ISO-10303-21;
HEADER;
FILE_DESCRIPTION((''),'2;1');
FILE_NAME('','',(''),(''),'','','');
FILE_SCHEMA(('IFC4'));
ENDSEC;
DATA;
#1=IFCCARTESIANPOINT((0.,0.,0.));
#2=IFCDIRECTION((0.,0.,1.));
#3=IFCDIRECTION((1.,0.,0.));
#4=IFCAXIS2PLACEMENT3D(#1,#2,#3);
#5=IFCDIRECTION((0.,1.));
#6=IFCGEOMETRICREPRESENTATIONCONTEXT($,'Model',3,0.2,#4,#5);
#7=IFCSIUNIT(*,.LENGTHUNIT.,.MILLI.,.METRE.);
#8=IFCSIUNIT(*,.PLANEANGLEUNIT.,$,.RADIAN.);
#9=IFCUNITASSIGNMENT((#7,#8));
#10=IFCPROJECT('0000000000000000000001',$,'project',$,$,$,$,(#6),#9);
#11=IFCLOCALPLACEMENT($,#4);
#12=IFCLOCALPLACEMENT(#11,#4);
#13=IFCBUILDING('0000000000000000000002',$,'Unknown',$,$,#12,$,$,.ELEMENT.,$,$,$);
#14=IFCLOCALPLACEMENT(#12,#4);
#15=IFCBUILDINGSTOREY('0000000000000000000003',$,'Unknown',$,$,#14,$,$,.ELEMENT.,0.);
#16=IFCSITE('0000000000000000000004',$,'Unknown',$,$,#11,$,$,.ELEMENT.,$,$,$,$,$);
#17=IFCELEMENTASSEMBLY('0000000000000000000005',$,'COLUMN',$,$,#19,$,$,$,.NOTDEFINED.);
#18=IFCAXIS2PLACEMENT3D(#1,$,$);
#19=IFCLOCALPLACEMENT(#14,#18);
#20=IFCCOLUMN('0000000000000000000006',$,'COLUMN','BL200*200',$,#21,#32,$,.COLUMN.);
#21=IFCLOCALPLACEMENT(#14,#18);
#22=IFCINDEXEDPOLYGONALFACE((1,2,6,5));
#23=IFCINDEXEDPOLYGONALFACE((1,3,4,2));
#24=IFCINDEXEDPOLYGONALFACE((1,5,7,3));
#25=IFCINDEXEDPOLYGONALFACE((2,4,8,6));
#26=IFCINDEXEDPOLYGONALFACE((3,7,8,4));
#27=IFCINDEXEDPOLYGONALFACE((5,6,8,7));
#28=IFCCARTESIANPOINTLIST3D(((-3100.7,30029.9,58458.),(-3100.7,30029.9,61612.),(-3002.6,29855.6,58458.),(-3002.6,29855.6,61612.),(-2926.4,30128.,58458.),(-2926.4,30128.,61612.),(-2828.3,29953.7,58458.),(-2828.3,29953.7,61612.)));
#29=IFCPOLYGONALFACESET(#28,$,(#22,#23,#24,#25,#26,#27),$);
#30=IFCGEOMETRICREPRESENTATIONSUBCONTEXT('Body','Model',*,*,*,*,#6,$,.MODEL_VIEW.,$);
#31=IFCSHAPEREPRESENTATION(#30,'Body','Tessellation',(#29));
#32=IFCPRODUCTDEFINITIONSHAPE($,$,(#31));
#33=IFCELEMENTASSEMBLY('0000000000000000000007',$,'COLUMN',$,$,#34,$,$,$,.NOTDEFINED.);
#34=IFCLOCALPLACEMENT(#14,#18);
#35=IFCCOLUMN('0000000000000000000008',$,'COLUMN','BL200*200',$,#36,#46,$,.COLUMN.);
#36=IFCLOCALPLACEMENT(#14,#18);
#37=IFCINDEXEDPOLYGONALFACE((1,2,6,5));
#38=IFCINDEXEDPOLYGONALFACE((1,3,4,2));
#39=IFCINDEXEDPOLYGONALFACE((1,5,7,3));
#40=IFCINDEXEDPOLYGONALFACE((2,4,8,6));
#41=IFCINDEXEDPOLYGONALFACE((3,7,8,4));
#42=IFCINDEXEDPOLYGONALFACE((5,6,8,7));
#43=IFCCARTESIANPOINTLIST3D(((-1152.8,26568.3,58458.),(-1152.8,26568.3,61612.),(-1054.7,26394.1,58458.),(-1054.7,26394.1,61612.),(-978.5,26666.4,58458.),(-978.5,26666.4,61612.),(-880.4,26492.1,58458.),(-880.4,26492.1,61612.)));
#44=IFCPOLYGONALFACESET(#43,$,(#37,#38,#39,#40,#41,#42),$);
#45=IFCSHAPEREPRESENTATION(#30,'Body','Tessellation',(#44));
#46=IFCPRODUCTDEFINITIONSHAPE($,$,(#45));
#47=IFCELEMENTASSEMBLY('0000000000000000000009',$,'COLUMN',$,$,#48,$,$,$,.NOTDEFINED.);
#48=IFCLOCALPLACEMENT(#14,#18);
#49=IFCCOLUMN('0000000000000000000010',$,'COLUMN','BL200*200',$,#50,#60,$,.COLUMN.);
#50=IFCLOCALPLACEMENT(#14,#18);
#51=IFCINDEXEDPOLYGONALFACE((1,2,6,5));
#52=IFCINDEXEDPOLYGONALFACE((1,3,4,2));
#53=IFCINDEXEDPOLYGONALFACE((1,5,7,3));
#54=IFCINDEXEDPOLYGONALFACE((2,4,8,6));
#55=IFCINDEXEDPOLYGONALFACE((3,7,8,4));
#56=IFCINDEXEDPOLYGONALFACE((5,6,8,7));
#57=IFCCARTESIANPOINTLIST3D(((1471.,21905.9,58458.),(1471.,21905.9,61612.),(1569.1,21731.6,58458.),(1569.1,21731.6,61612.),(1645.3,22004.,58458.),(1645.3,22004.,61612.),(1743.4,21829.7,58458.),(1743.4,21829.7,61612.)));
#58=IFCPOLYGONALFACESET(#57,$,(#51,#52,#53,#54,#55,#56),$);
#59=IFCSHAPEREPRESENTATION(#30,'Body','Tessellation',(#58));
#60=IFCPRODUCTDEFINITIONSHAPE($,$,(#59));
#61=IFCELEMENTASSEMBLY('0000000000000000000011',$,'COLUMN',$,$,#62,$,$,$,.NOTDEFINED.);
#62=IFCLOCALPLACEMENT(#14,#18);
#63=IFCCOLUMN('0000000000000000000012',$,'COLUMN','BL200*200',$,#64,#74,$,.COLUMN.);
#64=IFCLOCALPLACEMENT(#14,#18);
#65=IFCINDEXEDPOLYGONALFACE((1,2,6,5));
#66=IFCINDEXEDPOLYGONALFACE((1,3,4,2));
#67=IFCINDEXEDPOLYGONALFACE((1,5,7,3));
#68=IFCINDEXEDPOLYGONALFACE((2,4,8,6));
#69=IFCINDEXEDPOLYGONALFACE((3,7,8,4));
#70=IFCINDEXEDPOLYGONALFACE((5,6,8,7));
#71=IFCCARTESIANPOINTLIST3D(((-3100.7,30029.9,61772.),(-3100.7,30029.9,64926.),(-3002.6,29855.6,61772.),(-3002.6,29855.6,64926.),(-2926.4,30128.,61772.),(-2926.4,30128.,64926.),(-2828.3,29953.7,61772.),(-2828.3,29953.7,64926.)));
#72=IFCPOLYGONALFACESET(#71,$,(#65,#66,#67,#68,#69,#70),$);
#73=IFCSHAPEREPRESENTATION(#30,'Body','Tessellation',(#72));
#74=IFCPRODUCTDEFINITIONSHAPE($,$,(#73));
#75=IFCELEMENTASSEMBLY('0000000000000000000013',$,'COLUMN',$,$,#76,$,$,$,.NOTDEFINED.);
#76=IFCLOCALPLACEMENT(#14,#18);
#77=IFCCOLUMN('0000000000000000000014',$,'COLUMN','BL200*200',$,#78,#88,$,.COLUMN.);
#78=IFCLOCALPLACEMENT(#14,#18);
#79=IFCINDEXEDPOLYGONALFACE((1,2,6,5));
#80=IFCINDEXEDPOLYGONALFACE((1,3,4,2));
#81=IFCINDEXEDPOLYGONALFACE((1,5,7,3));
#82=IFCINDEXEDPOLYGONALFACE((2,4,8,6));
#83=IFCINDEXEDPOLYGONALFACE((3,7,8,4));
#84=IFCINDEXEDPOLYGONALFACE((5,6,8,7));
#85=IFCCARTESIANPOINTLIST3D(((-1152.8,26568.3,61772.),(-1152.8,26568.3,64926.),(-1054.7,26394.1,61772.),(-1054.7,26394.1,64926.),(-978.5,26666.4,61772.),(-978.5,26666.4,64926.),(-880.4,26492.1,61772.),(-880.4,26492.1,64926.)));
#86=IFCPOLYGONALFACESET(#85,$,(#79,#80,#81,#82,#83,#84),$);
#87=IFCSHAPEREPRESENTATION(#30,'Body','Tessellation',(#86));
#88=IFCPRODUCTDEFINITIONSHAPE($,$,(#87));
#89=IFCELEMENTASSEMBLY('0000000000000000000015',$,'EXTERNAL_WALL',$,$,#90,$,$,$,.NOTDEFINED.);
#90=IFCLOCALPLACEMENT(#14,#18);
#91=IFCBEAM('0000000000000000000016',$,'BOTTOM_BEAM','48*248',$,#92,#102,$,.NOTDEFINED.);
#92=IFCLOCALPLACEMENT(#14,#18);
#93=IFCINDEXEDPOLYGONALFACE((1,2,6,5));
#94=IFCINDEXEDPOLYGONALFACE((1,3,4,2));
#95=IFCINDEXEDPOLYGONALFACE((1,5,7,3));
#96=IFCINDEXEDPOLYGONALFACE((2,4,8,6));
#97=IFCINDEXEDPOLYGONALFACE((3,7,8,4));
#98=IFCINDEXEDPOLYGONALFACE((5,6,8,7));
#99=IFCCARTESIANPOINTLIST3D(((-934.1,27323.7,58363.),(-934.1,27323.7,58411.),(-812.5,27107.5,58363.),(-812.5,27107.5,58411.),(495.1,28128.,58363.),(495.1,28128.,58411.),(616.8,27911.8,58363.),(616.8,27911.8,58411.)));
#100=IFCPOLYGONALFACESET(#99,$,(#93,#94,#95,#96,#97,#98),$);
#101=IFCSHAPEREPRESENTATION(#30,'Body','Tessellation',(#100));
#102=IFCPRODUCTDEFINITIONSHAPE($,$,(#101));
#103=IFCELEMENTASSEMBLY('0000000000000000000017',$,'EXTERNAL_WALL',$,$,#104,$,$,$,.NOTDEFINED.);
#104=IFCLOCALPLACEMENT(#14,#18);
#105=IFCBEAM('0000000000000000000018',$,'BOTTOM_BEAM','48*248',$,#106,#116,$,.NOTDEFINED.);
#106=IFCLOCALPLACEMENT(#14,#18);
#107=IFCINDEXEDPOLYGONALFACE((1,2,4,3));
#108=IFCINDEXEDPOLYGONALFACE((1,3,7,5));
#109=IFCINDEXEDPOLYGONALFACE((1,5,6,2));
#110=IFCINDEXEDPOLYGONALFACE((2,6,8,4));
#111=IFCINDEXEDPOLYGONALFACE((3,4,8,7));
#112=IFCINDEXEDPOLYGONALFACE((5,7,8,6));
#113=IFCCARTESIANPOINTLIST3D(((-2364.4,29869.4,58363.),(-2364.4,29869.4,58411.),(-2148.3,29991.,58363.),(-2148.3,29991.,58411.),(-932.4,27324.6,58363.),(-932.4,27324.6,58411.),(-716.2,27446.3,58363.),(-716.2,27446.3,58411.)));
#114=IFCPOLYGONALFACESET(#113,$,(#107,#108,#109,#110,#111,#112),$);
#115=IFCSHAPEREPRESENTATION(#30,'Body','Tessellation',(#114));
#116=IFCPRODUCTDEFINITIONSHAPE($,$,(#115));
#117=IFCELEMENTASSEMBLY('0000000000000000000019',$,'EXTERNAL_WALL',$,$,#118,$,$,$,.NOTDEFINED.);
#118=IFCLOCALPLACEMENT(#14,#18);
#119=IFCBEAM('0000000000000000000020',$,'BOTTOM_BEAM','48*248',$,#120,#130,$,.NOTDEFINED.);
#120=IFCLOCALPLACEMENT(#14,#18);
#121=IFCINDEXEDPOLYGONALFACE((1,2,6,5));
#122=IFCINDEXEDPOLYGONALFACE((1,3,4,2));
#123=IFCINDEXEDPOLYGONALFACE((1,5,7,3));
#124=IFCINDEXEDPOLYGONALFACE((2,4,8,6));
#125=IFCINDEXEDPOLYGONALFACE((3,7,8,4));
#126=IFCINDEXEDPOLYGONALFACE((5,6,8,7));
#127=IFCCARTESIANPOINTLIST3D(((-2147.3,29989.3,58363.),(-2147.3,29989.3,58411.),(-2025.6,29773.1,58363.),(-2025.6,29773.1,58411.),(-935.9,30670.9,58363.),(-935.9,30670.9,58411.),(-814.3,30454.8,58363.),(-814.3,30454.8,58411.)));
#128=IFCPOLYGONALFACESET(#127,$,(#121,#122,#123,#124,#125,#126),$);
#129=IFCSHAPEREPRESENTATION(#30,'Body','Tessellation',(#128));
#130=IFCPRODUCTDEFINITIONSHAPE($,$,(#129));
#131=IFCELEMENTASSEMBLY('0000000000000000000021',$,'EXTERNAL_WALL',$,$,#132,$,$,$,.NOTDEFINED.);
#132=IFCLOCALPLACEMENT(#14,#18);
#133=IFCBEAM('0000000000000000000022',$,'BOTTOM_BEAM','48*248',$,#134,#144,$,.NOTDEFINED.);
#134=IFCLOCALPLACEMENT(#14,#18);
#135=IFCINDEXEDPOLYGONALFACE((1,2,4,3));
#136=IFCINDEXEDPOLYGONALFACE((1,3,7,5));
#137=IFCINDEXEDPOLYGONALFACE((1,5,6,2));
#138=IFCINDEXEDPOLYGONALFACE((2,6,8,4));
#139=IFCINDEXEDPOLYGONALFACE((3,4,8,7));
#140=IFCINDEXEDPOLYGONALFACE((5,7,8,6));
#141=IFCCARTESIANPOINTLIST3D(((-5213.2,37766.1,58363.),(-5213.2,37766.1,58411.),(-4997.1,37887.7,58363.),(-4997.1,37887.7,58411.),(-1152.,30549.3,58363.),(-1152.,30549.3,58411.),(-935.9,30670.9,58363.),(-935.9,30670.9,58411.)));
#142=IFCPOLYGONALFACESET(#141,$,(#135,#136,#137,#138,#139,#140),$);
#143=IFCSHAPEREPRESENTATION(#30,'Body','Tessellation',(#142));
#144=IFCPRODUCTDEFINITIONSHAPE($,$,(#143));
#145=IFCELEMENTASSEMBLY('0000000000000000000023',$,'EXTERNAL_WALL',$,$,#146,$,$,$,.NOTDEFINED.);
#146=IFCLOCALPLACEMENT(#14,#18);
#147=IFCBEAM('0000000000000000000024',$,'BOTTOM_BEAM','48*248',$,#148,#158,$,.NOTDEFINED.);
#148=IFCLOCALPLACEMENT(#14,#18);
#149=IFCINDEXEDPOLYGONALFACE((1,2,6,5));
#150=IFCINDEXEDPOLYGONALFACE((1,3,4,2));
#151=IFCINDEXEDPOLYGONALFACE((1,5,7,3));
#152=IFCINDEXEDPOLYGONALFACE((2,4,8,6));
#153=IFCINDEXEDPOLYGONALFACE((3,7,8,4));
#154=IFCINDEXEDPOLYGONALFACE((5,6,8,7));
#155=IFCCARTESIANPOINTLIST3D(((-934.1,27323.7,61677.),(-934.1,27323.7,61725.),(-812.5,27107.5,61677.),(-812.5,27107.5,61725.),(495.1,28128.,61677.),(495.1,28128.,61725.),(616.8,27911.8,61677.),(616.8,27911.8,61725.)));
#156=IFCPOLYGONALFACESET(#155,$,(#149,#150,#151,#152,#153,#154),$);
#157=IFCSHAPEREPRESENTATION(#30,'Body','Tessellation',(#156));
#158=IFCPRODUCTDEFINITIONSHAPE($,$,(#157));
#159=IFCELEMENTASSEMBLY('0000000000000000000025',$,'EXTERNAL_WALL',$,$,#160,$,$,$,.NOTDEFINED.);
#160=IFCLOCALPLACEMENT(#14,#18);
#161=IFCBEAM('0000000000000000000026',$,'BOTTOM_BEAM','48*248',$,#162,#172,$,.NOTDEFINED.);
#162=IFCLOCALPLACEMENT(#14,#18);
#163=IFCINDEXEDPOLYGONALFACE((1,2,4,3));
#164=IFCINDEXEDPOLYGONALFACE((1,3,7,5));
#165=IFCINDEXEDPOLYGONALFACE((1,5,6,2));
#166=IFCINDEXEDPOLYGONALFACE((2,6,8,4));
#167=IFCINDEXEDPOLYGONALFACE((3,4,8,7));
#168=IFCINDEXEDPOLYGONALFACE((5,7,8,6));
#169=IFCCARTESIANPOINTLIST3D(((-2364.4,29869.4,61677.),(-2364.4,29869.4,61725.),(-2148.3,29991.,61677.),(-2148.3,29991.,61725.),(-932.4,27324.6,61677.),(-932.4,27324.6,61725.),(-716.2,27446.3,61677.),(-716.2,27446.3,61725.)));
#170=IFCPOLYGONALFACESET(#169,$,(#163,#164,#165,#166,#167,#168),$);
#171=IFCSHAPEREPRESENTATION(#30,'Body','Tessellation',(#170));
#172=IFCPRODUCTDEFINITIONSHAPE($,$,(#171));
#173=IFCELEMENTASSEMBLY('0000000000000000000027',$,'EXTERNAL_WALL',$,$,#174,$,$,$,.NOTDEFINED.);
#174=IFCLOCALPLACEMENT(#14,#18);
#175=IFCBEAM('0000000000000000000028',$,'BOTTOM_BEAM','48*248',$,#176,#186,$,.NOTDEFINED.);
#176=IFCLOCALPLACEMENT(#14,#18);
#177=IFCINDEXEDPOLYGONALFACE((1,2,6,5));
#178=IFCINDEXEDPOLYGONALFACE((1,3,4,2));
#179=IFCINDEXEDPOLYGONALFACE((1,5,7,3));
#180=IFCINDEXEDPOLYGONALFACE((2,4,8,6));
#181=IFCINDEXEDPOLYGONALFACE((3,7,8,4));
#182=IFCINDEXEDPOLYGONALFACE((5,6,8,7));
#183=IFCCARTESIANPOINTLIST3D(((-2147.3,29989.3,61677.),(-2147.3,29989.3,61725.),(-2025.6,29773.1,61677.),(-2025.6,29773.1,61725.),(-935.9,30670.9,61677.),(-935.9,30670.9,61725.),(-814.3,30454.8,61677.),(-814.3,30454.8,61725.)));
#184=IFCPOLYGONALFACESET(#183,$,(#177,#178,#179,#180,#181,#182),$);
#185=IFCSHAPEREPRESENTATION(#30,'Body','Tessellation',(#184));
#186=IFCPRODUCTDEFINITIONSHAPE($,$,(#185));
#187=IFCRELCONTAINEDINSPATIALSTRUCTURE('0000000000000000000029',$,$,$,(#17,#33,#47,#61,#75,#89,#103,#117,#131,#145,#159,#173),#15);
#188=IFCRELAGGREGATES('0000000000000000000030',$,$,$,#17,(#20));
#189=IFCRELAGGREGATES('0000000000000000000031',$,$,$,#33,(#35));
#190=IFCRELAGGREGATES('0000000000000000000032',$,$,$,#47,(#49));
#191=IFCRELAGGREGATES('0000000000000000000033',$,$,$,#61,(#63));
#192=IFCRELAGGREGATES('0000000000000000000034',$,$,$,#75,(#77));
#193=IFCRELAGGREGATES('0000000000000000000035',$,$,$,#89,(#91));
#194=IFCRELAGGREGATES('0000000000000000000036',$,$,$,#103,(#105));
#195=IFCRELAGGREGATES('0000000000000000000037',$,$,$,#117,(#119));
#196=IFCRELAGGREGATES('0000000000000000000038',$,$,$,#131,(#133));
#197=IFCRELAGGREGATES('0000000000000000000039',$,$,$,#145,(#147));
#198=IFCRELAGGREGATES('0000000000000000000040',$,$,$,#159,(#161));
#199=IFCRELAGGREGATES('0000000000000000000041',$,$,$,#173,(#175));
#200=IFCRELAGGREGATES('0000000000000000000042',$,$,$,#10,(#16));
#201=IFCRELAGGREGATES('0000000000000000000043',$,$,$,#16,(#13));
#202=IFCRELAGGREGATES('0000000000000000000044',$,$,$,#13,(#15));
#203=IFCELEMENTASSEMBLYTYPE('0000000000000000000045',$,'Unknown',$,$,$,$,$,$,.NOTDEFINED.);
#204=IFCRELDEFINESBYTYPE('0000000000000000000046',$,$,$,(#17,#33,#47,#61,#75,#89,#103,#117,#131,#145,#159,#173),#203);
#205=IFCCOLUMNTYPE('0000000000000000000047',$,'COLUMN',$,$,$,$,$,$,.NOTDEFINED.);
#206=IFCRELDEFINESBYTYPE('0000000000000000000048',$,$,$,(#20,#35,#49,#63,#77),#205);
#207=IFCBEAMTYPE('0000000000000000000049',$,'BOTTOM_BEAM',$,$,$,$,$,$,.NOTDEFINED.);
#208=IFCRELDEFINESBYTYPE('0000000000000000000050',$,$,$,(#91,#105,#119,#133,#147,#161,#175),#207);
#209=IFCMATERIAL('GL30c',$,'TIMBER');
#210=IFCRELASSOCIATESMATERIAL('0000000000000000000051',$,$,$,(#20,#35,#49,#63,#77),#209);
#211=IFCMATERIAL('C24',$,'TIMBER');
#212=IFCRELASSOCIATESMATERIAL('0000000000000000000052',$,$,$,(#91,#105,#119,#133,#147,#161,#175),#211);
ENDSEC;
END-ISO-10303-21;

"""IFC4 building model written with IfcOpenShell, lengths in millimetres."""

from ifc_helpers import new_model, si_unit, direction, frame, origin_with_axes, origin_2d_with_axis, place, context, subcontext, project, spatial, rectangle, extrude, material, material_profile, profile_set, profile_usage, type_object, element, aggregate, save


model = new_model("IFC4")

# Units and contexts
model_context = context("Model", 3, precision=0.2, world=origin_with_axes(), true_north=direction((0.0, 1.0)))
body_context = subcontext(model_context, "Body", "Model", "MODEL_VIEW")
ifc_project = project(units=[si_unit("LENGTHUNIT", "METRE", prefix="MILLI"), si_unit("PLANEANGLEUNIT", "RADIAN")], contexts=[model_context])

# Site, building, storey
site_placement = place(None, origin_with_axes())
site = spatial("IfcSite", under=ifc_project, at=site_placement, Name="Unknown", CompositionType="ELEMENT")
building_placement = place(site_placement, origin_with_axes())
building = spatial("IfcBuilding", under=site, at=building_placement, Name="Unknown", CompositionType="ELEMENT")
storey_placement = place(building_placement, origin_with_axes())
storey = spatial("IfcBuildingStorey", under=building, at=storey_placement, Name="Unknown", CompositionType="ELEMENT", Elevation=0.0)

# Element assemblies, columns
element_assembly_type = type_object("IfcElementAssemblyType", Name="Unknown", PredefinedType="NOTDEFINED")
assembly_1_placement = place(storey_placement, frame((-2964.5, 29991.8, 58458.0), z_axis=(-0.871487, -0.490418, 0.0), x_axis=(0.0, 0.0, 1.0)))
assembly_1 = element("IfcElementAssembly", 1, at=assembly_1_placement, inside=storey, type_object=element_assembly_type, Name="COLUMN", PredefinedType="NOTDEFINED")
ifc_material_1 = material(Name="GL30c", Category="TIMBER")
ifc_material_profile_1 = material_profile(ifc_material_1, rectangle(XDim=200.0, YDim=200.0, at=origin_2d_with_axis()), Name="BL200*200")
ifc_profile_set_1 = profile_set([ifc_material_profile_1])
ifc_profile_usage_1 = profile_usage(ifc_profile_set_1, cardinal=5)
column_type = type_object("IfcColumnType", Name="COLUMN")
column_1_placement = place(assembly_1_placement, origin_with_axes())
column_1 = element("IfcColumn", 2, at=column_1_placement, type_object=column_type, material=ifc_profile_usage_1, Name="COLUMN", Description="BL200*200", PredefinedType="COLUMN", context=body_context, shape_type="SolidModel", body=[
    extrude(rectangle(XDim=200.0, YDim=200.0, at=origin_2d_with_axis()), frame((0.0, 0.0, 0.0), z_axis=(-1.0, 0.0, 0.0), x_axis=(0.0, 0.0, 1.0)), (0.0, 0.0, -1.0), 3154.0),
])
aggregate(assembly_1, [column_1])
assembly_2_placement = place(storey_placement, frame((-1016.6, 26530.2, 58458.0), z_axis=(-0.871487, -0.490418, 0.0), x_axis=(0.0, 0.0, 1.0)))
assembly_2 = element("IfcElementAssembly", 3, at=assembly_2_placement, inside=storey, type_object=element_assembly_type, Name="COLUMN", PredefinedType="NOTDEFINED")
column_2_placement = place(assembly_2_placement, origin_with_axes())
column_2 = element("IfcColumn", 4, at=column_2_placement, type_object=column_type, material=ifc_profile_usage_1, Name="COLUMN", Description="BL200*200", PredefinedType="COLUMN", context=body_context, shape_type="SolidModel", body=[
    extrude(rectangle(XDim=200.0, YDim=200.0, at=origin_2d_with_axis()), frame((0.0, 0.0, 0.0), z_axis=(-1.0, 0.0, 0.0), x_axis=(0.0, 0.0, 1.0)), (0.0, 0.0, -1.0), 3154.0),
])
aggregate(assembly_2, [column_2])
assembly_3_placement = place(storey_placement, frame((1607.2, 21867.8, 58458.0), z_axis=(-0.871487, -0.490418, 0.0), x_axis=(0.0, 0.0, 1.0)))
assembly_3 = element("IfcElementAssembly", 5, at=assembly_3_placement, inside=storey, type_object=element_assembly_type, Name="COLUMN", PredefinedType="NOTDEFINED")
column_3_placement = place(assembly_3_placement, origin_with_axes())
column_3 = element("IfcColumn", 6, at=column_3_placement, type_object=column_type, material=ifc_profile_usage_1, Name="COLUMN", Description="BL200*200", PredefinedType="COLUMN", context=body_context, shape_type="SolidModel", body=[
    extrude(rectangle(XDim=200.0, YDim=200.0, at=origin_2d_with_axis()), frame((0.0, 0.0, 0.0), z_axis=(-1.0, 0.0, 0.0), x_axis=(0.0, 0.0, 1.0)), (0.0, 0.0, -1.0), 3154.0),
])
aggregate(assembly_3, [column_3])
assembly_4_placement = place(storey_placement, frame((-2964.5, 29991.8, 61772.0), z_axis=(-0.871487, -0.490418, 0.0), x_axis=(0.0, 0.0, 1.0)))
assembly_4 = element("IfcElementAssembly", 7, at=assembly_4_placement, inside=storey, type_object=element_assembly_type, Name="COLUMN", PredefinedType="NOTDEFINED")
column_4_placement = place(assembly_4_placement, origin_with_axes())
column_4 = element("IfcColumn", 8, at=column_4_placement, type_object=column_type, material=ifc_profile_usage_1, Name="COLUMN", Description="BL200*200", PredefinedType="COLUMN", context=body_context, shape_type="SolidModel", body=[
    extrude(rectangle(XDim=200.0, YDim=200.0, at=origin_2d_with_axis()), frame((0.0, 0.0, 0.0), z_axis=(-1.0, 0.0, 0.0), x_axis=(0.0, 0.0, 1.0)), (0.0, 0.0, -1.0), 3154.0),
])
aggregate(assembly_4, [column_4])
assembly_5_placement = place(storey_placement, frame((-1016.6, 26530.2, 61772.0), z_axis=(-0.871487, -0.490418, 0.0), x_axis=(0.0, 0.0, 1.0)))
assembly_5 = element("IfcElementAssembly", 9, at=assembly_5_placement, inside=storey, type_object=element_assembly_type, Name="COLUMN", PredefinedType="NOTDEFINED")
column_5_placement = place(assembly_5_placement, origin_with_axes())
column_5 = element("IfcColumn", 10, at=column_5_placement, type_object=column_type, material=ifc_profile_usage_1, Name="COLUMN", Description="BL200*200", PredefinedType="COLUMN", context=body_context, shape_type="SolidModel", body=[
    extrude(rectangle(XDim=200.0, YDim=200.0, at=origin_2d_with_axis()), frame((0.0, 0.0, 0.0), z_axis=(-1.0, 0.0, 0.0), x_axis=(0.0, 0.0, 1.0)), (0.0, 0.0, -1.0), 3154.0),
])
aggregate(assembly_5, [column_5])

# Element assemblies, beams
assembly_6_placement = place(storey_placement, frame((556.0, 28019.9, 61622.0), z_axis=(-0.490421, 0.871486, 0.0), x_axis=(-0.871487, -0.490418, 0.0)))
assembly_6 = element("IfcElementAssembly", 11, at=assembly_6_placement, inside=storey, type_object=element_assembly_type, Name="EXTERNAL_WALL", PredefinedType="NOTDEFINED")
ifc_material_2 = material(Name="C24", Category="TIMBER")
ifc_material_profile_2 = material_profile(ifc_material_2, rectangle(XDim=248.0, YDim=48.0, at=origin_2d_with_axis()), Name="48*248")
ifc_profile_set_2 = profile_set([ifc_material_profile_2])
ifc_profile_usage_2 = profile_usage(ifc_profile_set_2, cardinal=3)
beam_type_1 = type_object("IfcBeamType", Name="BOTTOM_BEAM")
beam_1_placement = place(assembly_6_placement, frame((0.0, -3235.0, 0.0), z_axis=(0.0, 0.0, 1.0), x_axis=(1.0, 0.0, 0.0)))
beam_1 = element("IfcBeam", 12, at=beam_1_placement, type_object=beam_type_1, material=ifc_profile_usage_2, Name="BOTTOM_BEAM", Description="48*248", PredefinedType="NOTDEFINED", context=body_context, shape_type="SolidModel", body=[
    extrude(rectangle(XDim=248.0, YDim=48.0, at=origin_2d_with_axis()), frame((0.0, 0.0, 0.0), z_axis=(-1.0, 0.0, 0.0), x_axis=(0.0, 0.0, 1.0)), (0.0, 0.0, -1.0), 1640.0),
])
assembly_7_placement = place(storey_placement, frame((-824.3, 27385.5, 61622.0), z_axis=(0.871484, 0.490423, 0.0), x_axis=(-0.490421, 0.871486, 0.0)))
assembly_7 = element("IfcElementAssembly", 13, at=assembly_7_placement, inside=storey, type_object=element_assembly_type, Name="EXTERNAL_WALL", PredefinedType="NOTDEFINED")
beam_2_placement = place(assembly_7_placement, frame((0.0, -3235.0, 0.0), z_axis=(0.0, 0.0, 1.0), x_axis=(1.0, 0.0, 0.0)))
beam_2 = element("IfcBeam", 14, at=beam_2_placement, type_object=beam_type_1, material=ifc_profile_usage_2, Name="BOTTOM_BEAM", Description="48*248", PredefinedType="NOTDEFINED", context=body_context, shape_type="SolidModel", body=[
    extrude(rectangle(XDim=248.0, YDim=48.0, at=origin_2d_with_axis()), frame((0.0, 0.0, 0.0), z_axis=(-1.0, 0.0, 0.0), x_axis=(0.0, 0.0, 1.0)), (0.0, 0.0, -1.0), 2920.0),
])
assembly_8_placement = place(storey_placement, frame((-2086.5, 29881.2, 61622.0), z_axis=(0.490421, -0.871485, 0.0), x_axis=(0.871484, 0.490423, 0.0)))
assembly_8 = element("IfcElementAssembly", 15, at=assembly_8_placement, inside=storey, type_object=element_assembly_type, Name="EXTERNAL_WALL", PredefinedType="NOTDEFINED")
beam_3_placement = place(assembly_8_placement, frame((0.0, -3235.0, 0.0), z_axis=(0.0, 0.0, 1.0), x_axis=(1.0, 0.0, 0.0)))
beam_3 = element("IfcBeam", 16, at=beam_3_placement, type_object=beam_type_1, material=ifc_profile_usage_2, Name="BOTTOM_BEAM", Description="48*248", PredefinedType="NOTDEFINED", context=body_context, shape_type="SolidModel", body=[
    extrude(rectangle(XDim=248.0, YDim=48.0, at=origin_2d_with_axis()), frame((0.0, 0.0, 0.0), z_axis=(-1.0, 0.0, 0.0), x_axis=(0.0, 0.0, 1.0)), (0.0, 0.0, -1.0), 1390.0),
])
assembly_9_placement = place(storey_placement, frame((-1044.0, 30610.1, 61622.0), z_axis=(0.871484, 0.490423, 0.0), x_axis=(-0.490421, 0.871486, 0.0)))
assembly_9 = element("IfcElementAssembly", 17, at=assembly_9_placement, inside=storey, type_object=element_assembly_type, Name="EXTERNAL_WALL", PredefinedType="NOTDEFINED")
beam_4_placement = place(assembly_9_placement, frame((0.0, -3235.0, 0.0), z_axis=(0.0, 0.0, 1.0), x_axis=(1.0, 0.0, 0.0)))
beam_4 = element("IfcBeam", 18, at=beam_4_placement, type_object=beam_type_1, material=ifc_profile_usage_2, Name="BOTTOM_BEAM", Description="48*248", PredefinedType="NOTDEFINED", context=body_context, shape_type="SolidModel", body=[
    extrude(rectangle(XDim=248.0, YDim=48.0, at=origin_2d_with_axis()), frame((0.0, 0.0, 0.0), z_axis=(-1.0, 0.0, 0.0), x_axis=(0.0, 0.0, 1.0)), (0.0, 0.0, -1.0), 8281.0),
])
assembly_10_placement = place(storey_placement, frame((556.0, 28019.9, 64936.0), z_axis=(-0.490421, 0.871486, 0.0), x_axis=(-0.871487, -0.490418, 0.0)))
assembly_10 = element("IfcElementAssembly", 19, at=assembly_10_placement, inside=storey, type_object=element_assembly_type, Name="EXTERNAL_WALL", PredefinedType="NOTDEFINED")
beam_5_placement = place(assembly_10_placement, frame((0.0, -3235.0, 0.0), z_axis=(0.0, 0.0, 1.0), x_axis=(1.0, 0.0, 0.0)))
beam_5 = element("IfcBeam", 20, at=beam_5_placement, type_object=beam_type_1, material=ifc_profile_usage_2, Name="BOTTOM_BEAM", Description="48*248", PredefinedType="NOTDEFINED", context=body_context, shape_type="SolidModel", body=[
    extrude(rectangle(XDim=248.0, YDim=48.0, at=origin_2d_with_axis()), frame((0.0, 0.0, 0.0), z_axis=(-1.0, 0.0, 0.0), x_axis=(0.0, 0.0, 1.0)), (0.0, 0.0, -1.0), 1640.0),
])
assembly_11_placement = place(storey_placement, frame((-824.3, 27385.5, 64936.0), z_axis=(0.871484, 0.490423, 0.0), x_axis=(-0.490421, 0.871486, 0.0)))
assembly_11 = element("IfcElementAssembly", 21, at=assembly_11_placement, inside=storey, type_object=element_assembly_type, Name="EXTERNAL_WALL", PredefinedType="NOTDEFINED")
beam_6_placement = place(assembly_11_placement, frame((0.0, -3235.0, 0.0), z_axis=(0.0, 0.0, 1.0), x_axis=(1.0, 0.0, 0.0)))
beam_6 = element("IfcBeam", 22, at=beam_6_placement, type_object=beam_type_1, material=ifc_profile_usage_2, Name="BOTTOM_BEAM", Description="48*248", PredefinedType="NOTDEFINED", context=body_context, shape_type="SolidModel", body=[
    extrude(rectangle(XDim=248.0, YDim=48.0, at=origin_2d_with_axis()), frame((0.0, 0.0, 0.0), z_axis=(-1.0, 0.0, 0.0), x_axis=(0.0, 0.0, 1.0)), (0.0, 0.0, -1.0), 2920.0),
])
assembly_12_placement = place(storey_placement, frame((-2086.5, 29881.2, 64936.0), z_axis=(0.490421, -0.871485, 0.0), x_axis=(0.871484, 0.490423, 0.0)))
assembly_12 = element("IfcElementAssembly", 23, at=assembly_12_placement, inside=storey, type_object=element_assembly_type, Name="EXTERNAL_WALL", PredefinedType="NOTDEFINED")
beam_7_placement = place(assembly_12_placement, frame((0.0, -3235.0, 0.0), z_axis=(0.0, 0.0, 1.0), x_axis=(1.0, 0.0, 0.0)))
beam_7 = element("IfcBeam", 24, at=beam_7_placement, type_object=beam_type_1, material=ifc_profile_usage_2, Name="BOTTOM_BEAM", Description="48*248", PredefinedType="NOTDEFINED", context=body_context, shape_type="SolidModel", body=[
    extrude(rectangle(XDim=248.0, YDim=48.0, at=origin_2d_with_axis()), frame((0.0, 0.0, 0.0), z_axis=(-1.0, 0.0, 0.0), x_axis=(0.0, 0.0, 1.0)), (0.0, 0.0, -1.0), 1390.0),
])

aggregate(assembly_6, [beam_1])
aggregate(assembly_7, [beam_2])
aggregate(assembly_8, [beam_3])
aggregate(assembly_9, [beam_4])
aggregate(assembly_10, [beam_5])
aggregate(assembly_11, [beam_6])
aggregate(assembly_12, [beam_7])

save(model, "model.ifc")
